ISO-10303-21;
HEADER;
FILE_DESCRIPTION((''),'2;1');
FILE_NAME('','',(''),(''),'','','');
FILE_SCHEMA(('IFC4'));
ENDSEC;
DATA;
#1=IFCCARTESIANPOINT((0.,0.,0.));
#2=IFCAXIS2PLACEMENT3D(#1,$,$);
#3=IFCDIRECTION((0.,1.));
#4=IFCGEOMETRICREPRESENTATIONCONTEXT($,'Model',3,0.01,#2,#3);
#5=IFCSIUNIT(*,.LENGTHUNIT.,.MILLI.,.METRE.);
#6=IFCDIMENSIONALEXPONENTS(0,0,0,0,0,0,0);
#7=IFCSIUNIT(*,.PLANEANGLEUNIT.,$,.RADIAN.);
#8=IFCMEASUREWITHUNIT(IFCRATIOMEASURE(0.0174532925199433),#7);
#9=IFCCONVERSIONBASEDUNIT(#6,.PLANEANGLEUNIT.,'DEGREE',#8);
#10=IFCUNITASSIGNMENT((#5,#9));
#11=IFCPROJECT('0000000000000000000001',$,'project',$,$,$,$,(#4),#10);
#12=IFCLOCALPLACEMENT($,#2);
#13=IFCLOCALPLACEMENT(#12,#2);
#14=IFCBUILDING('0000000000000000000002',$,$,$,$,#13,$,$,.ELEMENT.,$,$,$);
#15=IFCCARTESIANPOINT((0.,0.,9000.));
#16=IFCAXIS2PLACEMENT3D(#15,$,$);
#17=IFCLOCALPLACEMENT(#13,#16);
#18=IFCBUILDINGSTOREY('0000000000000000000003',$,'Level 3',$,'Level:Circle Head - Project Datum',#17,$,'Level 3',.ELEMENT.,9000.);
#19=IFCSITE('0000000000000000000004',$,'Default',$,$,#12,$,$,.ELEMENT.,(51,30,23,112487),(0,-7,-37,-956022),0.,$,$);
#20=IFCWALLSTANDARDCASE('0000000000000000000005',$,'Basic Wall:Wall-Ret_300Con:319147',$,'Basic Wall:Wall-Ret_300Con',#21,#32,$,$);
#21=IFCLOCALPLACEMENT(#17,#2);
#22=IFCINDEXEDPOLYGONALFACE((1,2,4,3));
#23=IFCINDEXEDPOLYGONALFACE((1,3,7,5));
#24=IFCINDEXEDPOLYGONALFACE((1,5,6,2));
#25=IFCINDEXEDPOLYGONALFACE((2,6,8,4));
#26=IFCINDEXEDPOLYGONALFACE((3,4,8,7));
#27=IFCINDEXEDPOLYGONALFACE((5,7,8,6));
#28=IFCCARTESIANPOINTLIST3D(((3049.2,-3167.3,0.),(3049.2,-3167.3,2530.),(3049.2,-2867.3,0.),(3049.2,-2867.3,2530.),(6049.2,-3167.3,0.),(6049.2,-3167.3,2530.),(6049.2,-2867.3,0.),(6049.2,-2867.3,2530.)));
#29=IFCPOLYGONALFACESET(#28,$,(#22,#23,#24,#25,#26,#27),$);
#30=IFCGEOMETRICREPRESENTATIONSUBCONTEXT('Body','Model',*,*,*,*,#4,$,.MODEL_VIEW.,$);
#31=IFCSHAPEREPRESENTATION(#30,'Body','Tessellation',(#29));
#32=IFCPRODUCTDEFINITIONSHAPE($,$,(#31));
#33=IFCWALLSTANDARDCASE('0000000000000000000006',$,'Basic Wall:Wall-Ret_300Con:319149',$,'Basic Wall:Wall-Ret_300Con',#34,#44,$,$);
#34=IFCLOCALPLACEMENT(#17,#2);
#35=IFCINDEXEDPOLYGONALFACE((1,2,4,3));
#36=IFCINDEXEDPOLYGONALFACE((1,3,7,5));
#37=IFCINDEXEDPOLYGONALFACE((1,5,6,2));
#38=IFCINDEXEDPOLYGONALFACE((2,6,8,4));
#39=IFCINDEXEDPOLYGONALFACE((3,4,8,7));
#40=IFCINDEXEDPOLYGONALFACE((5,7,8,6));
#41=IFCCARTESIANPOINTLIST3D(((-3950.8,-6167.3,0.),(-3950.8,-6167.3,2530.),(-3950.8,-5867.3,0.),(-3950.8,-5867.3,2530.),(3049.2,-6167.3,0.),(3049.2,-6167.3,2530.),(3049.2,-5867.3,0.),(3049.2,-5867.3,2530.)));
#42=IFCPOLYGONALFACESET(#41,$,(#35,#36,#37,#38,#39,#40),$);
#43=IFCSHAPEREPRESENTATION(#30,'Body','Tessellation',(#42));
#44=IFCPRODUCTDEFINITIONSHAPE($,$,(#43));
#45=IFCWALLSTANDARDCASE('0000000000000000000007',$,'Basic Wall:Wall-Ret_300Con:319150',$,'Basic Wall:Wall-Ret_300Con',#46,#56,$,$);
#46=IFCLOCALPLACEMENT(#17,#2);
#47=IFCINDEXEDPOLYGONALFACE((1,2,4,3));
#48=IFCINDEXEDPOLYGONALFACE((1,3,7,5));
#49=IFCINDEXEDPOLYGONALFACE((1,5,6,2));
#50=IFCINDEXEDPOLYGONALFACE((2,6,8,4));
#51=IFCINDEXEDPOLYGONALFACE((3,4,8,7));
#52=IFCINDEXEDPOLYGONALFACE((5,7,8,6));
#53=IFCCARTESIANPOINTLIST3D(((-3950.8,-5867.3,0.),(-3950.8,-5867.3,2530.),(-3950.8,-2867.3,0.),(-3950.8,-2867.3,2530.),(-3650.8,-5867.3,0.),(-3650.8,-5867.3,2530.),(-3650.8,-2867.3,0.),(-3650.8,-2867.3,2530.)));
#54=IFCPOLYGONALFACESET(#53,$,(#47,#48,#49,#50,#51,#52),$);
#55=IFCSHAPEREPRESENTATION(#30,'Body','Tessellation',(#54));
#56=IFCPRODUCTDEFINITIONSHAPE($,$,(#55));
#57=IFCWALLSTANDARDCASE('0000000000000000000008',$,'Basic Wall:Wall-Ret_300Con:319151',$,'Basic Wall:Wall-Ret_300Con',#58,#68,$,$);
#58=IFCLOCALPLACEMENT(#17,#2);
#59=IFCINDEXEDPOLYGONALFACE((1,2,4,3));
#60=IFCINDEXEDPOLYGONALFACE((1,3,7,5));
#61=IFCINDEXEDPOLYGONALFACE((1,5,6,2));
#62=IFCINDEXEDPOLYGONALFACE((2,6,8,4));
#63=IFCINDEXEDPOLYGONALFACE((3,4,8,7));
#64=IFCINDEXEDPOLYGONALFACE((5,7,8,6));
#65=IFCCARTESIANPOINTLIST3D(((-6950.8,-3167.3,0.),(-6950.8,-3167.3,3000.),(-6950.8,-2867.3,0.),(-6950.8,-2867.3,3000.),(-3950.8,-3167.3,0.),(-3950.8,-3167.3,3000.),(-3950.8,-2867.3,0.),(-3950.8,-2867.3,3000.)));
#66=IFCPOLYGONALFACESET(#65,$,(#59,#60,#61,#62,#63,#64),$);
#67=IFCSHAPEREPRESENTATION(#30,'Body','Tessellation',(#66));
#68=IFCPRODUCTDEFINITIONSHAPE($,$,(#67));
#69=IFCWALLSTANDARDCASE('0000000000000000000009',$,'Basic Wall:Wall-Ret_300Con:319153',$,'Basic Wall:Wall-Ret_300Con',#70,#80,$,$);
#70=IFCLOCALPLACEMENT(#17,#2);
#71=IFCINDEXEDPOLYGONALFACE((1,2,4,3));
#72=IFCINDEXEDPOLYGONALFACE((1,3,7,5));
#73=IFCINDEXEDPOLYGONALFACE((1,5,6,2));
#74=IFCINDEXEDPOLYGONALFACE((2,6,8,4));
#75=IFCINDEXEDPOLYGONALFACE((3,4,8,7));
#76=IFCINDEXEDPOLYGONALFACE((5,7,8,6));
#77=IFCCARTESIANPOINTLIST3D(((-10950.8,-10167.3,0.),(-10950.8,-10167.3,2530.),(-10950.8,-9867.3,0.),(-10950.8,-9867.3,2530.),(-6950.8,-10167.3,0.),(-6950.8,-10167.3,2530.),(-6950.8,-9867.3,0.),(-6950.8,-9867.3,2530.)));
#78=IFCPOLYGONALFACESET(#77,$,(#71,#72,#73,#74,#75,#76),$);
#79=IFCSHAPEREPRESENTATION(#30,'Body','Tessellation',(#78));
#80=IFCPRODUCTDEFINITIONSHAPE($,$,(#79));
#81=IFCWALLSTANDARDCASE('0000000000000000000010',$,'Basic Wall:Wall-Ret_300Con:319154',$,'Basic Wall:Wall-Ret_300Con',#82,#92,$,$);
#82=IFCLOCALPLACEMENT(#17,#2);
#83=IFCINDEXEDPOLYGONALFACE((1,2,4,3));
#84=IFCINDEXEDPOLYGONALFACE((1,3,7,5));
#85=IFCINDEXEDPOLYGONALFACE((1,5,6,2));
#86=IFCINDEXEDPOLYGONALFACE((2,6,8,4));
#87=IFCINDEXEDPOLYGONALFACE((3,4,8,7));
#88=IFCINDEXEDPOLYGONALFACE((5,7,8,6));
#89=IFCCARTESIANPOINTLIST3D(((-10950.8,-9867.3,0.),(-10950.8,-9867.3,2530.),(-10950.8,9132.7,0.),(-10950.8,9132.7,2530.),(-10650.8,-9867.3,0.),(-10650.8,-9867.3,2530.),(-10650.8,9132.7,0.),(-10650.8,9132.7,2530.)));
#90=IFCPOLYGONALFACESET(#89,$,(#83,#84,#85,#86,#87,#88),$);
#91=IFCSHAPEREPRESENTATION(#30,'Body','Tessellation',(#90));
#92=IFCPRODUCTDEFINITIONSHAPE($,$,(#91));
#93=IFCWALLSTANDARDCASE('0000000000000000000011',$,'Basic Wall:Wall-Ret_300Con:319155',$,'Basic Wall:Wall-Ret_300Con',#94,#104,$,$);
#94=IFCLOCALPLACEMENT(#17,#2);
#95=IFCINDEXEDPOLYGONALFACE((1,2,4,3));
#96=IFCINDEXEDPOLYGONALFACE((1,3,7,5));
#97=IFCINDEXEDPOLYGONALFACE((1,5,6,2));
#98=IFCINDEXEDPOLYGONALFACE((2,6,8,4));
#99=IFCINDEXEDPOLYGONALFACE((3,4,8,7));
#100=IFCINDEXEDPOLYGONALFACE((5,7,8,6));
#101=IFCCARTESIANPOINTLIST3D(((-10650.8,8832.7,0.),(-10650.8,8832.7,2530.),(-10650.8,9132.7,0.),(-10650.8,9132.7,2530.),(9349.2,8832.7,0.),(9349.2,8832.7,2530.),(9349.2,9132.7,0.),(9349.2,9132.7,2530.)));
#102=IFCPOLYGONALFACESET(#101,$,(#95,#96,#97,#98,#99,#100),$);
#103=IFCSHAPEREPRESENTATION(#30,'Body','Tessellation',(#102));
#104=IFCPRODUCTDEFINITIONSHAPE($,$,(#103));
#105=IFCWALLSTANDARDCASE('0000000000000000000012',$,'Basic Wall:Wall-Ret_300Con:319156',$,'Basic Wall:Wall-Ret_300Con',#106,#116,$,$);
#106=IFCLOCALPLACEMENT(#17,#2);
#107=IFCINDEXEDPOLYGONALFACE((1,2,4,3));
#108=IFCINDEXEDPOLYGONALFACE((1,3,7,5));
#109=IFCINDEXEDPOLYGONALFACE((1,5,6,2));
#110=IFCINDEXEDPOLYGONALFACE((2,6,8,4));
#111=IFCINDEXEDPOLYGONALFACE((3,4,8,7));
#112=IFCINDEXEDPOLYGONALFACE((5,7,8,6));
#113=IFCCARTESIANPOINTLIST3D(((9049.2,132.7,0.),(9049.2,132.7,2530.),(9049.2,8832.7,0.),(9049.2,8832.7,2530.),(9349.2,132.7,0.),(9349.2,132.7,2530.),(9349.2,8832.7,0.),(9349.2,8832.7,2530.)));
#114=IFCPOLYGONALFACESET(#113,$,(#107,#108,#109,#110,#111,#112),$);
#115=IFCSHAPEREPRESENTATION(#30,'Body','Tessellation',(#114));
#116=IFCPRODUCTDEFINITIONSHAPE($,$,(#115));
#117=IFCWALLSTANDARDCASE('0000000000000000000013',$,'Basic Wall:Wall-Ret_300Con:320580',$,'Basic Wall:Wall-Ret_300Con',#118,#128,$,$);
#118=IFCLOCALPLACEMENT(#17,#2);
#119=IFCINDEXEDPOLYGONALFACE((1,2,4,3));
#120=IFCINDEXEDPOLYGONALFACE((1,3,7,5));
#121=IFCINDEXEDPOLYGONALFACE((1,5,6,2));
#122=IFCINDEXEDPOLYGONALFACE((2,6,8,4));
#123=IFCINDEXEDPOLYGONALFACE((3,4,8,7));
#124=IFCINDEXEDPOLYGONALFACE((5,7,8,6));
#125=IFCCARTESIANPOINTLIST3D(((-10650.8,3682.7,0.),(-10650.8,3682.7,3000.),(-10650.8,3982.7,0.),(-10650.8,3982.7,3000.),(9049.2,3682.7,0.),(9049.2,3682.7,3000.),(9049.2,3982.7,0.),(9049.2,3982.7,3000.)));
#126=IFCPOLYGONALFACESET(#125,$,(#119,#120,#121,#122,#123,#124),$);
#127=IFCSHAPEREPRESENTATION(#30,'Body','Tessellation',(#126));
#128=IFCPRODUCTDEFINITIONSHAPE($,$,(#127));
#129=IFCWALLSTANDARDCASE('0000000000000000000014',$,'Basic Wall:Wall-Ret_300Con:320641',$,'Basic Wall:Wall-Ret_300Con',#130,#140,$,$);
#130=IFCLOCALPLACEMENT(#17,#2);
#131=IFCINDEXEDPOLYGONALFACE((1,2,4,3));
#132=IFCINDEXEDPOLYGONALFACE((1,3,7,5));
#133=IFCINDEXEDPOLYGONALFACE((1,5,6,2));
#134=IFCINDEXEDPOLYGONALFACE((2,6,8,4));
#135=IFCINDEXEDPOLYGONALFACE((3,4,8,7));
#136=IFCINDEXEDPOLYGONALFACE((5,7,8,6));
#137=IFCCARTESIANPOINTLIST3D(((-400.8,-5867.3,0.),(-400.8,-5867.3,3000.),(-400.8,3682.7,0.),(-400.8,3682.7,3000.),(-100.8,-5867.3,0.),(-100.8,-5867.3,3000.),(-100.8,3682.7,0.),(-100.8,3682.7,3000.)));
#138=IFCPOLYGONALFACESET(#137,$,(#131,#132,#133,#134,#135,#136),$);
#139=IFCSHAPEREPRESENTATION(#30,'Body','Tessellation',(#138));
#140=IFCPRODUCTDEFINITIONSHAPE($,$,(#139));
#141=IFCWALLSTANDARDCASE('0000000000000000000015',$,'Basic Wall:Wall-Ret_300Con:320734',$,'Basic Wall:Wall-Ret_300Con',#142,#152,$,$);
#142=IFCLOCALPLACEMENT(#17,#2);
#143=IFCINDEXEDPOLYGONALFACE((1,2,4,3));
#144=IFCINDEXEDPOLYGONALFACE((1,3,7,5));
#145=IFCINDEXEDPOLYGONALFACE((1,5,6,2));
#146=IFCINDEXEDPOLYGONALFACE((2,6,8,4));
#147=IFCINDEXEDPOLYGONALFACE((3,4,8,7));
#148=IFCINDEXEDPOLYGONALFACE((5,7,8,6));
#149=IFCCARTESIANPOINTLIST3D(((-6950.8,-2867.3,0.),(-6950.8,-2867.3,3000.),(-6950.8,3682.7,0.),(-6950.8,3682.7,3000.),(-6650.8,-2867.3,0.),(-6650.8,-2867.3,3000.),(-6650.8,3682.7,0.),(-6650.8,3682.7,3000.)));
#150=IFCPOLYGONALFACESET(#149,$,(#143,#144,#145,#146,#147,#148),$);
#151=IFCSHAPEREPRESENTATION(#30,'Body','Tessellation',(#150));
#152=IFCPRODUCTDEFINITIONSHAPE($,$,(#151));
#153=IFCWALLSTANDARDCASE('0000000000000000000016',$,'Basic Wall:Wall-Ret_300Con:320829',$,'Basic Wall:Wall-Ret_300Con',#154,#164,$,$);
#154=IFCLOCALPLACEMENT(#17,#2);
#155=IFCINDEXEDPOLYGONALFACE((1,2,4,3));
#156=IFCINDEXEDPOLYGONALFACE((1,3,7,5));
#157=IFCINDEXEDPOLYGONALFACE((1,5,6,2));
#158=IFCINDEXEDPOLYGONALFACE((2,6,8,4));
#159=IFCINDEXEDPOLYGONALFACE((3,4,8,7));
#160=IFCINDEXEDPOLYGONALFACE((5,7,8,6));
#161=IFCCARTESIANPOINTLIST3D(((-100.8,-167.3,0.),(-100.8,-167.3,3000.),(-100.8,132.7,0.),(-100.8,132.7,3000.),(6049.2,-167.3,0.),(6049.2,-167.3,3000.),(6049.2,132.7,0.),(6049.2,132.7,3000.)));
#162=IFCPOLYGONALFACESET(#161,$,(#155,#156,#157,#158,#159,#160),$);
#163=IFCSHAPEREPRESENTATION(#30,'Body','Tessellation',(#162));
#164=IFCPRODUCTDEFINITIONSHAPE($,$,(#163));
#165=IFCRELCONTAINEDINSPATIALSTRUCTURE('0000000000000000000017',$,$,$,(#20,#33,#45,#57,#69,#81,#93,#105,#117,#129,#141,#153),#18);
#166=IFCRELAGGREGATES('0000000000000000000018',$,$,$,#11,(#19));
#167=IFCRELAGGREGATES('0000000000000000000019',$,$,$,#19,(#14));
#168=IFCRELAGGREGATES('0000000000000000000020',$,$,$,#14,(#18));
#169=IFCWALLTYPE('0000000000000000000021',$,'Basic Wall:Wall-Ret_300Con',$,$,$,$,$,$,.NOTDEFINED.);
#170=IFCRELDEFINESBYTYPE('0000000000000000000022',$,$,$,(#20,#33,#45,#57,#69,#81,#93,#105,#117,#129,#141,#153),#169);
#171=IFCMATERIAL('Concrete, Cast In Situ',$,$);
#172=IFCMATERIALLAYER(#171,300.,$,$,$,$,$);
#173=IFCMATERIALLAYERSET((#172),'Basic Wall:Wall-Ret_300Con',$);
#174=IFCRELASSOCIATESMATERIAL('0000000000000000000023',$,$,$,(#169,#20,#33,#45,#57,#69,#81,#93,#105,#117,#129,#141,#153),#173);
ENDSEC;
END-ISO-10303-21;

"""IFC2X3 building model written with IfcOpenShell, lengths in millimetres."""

from ifc_helpers import new_model, entity, si_unit, converted_unit, direction, frame, frame_2d, origin, place, context, subcontext, project, spatial, polyline, rectangle, extrude, clip, bounded_halfspace, material, layer, layer_set, layer_usage, type_object, element, save


model = new_model("IFC2X3")

# Units and contexts
model_context = context("Model", 3, precision=0.01, world=origin(), true_north=direction((0.0, 1.0)))
body_context = subcontext(model_context, "Body", "Model", "MODEL_VIEW")
ifc_project = project(units=[si_unit("LENGTHUNIT", "METRE", prefix="MILLI"), converted_unit("PLANEANGLEUNIT", "DEGREE", entity("IfcRatioMeasure", 0.0174532925199433), si_unit("PLANEANGLEUNIT", "RADIAN"), dimensions=[0, 0, 0, 0, 0, 0, 0])], contexts=[model_context])

# Site, building, storey
site_placement = place(None, origin())
site = spatial("IfcSite", under=ifc_project, at=site_placement, Name="Default", CompositionType="ELEMENT", RefLatitude=(51, 30, 23, 112487), RefLongitude=(0, -7, -37, -956022), RefElevation=0.0)
building_placement = place(site_placement, origin())
building = spatial("IfcBuilding", under=site, at=building_placement, CompositionType="ELEMENT")
storey_placement = place(building_placement, frame((0.0, 0.0, 9000.0)))
storey = spatial("IfcBuildingStorey", under=building, at=storey_placement, Name="Level 3", ObjectType="Level:Circle Head - Project Datum", LongName="Level 3", CompositionType="ELEMENT", Elevation=9000.0)

# Walls
ifc_material_1 = material(Name="Concrete, Cast In Situ")
ifc_layer_1 = layer(ifc_material_1, 300.0)
ifc_layer_set_1 = layer_set([ifc_layer_1], Name="Basic Wall:Wall-Ret_300Con")
wall_type = type_object("IfcWallType", Name="Basic Wall:Wall-Ret_300Con", PredefinedType="NOTDEFINED", material=ifc_layer_set_1)
ifc_layer_usage_1 = layer_usage(ifc_layer_set_1, "AXIS2", "NEGATIVE", 150.0)
wall_1_placement = place(storey_placement, frame((6049.2, -3017.3, 0.0), z_axis=(0.0, 0.0, 1.0), x_axis=(-1.0, 0.0, 0.0)))
element("IfcWallStandardCase", 1, at=wall_1_placement, inside=storey, type_object=wall_type, material=ifc_layer_usage_1, Name="Basic Wall:Wall-Ret_300Con:319147", ObjectType="Basic Wall:Wall-Ret_300Con", context=body_context, shape_type="Clipping", body=[
    clip(extrude(rectangle(XDim=3000.0, YDim=300.0, at=frame_2d((1500.0, 0.0), x_axis=(-1.0, 0.0))), origin(), (0.0, 0.0, 1.0), 2530.0), bounded_halfspace(frame((0.0, -150.0, 2530.0), z_axis=(0.0, 0.0, -1.0), x_axis=(-1.0, 0.0, 0.0)), True, frame((0.0, -150.0, 2530.0)), polyline([(0.0, 0.0), (3000.0, 0.0), (3000.0, 298.0), (2701.3, 298.0), (0.0, 298.0), (0.0, 0.0)]))),
])
ifc_layer_usage_2 = layer_usage(ifc_layer_set_1, "AXIS2", "NEGATIVE", 150.0)
wall_2_placement = place(storey_placement, frame((3049.2, -6017.3, 0.0), z_axis=(0.0, 0.0, 1.0), x_axis=(-1.0, 0.0, 0.0)))
element("IfcWallStandardCase", 2, at=wall_2_placement, inside=storey, type_object=wall_type, material=ifc_layer_usage_2, Name="Basic Wall:Wall-Ret_300Con:319149", ObjectType="Basic Wall:Wall-Ret_300Con", context=body_context, shape_type="Clipping", body=[
    clip(extrude(rectangle(XDim=7000.0, YDim=300.0, at=frame_2d((3500.0, 0.0), x_axis=(-1.0, 0.0))), origin(), (0.0, 0.0, 1.0), 2530.0), bounded_halfspace(frame((0.0, -150.0, 2530.0), z_axis=(0.0, 0.0, -1.0), x_axis=(-1.0, 0.0, 0.0)), True, frame((0.0, -150.0, 2530.0)), polyline([(0.0, 0.0), (6700.0, 0.0), (7000.0, 0.0), (7000.0, 298.0), (0.0, 298.0), (0.0, 0.0)]))),
])
ifc_layer_usage_3 = layer_usage(ifc_layer_set_1, "AXIS2", "NEGATIVE", 150.0)
wall_3_placement = place(storey_placement, frame((-3800.8, -5867.3, 0.0), z_axis=(0.0, 0.0, 1.0), x_axis=(0.0, 1.0, 0.0)))
element("IfcWallStandardCase", 3, at=wall_3_placement, inside=storey, type_object=wall_type, material=ifc_layer_usage_3, Name="Basic Wall:Wall-Ret_300Con:319150", ObjectType="Basic Wall:Wall-Ret_300Con", context=body_context, shape_type="Clipping", body=[
    clip(extrude(rectangle(XDim=3000.0, YDim=300.0, at=frame_2d((1500.0, 0.0), x_axis=(-1.0, 0.0))), origin(), (0.0, 0.0, 1.0), 2530.0), bounded_halfspace(frame((0.0, -150.0, 2530.0), z_axis=(0.0, 0.0, -1.0), x_axis=(0.0, -1.0, 0.0)), True, frame((0.0, -150.0, 2530.0)), polyline([(0.0, 0.0), (3000.0, 0.0), (3000.0, 300.0), (0.0, 300.0), (0.0, 0.0)]))),
])
ifc_layer_usage_4 = layer_usage(ifc_layer_set_1, "AXIS2", "NEGATIVE", 150.0)
wall_4_placement = place(storey_placement, frame((-3950.8, -3017.3, 0.0), z_axis=(0.0, 0.0, 1.0), x_axis=(-1.0, 0.0, 0.0)))
element("IfcWallStandardCase", 4, at=wall_4_placement, inside=storey, type_object=wall_type, material=ifc_layer_usage_4, Name="Basic Wall:Wall-Ret_300Con:319151", ObjectType="Basic Wall:Wall-Ret_300Con", context=body_context, shape_type="SweptSolid", body=[
    extrude(rectangle(XDim=3000.0, YDim=300.0, at=frame_2d((1500.0, 0.0), x_axis=(-1.0, 0.0))), origin(), (0.0, 0.0, 1.0), 3000.0),
])
ifc_layer_usage_5 = layer_usage(ifc_layer_set_1, "AXIS2", "NEGATIVE", 150.0)
wall_5_placement = place(storey_placement, frame((-6950.8, -10017.3, 0.0), z_axis=(0.0, 0.0, 1.0), x_axis=(-1.0, 0.0, 0.0)))
element("IfcWallStandardCase", 5, at=wall_5_placement, inside=storey, type_object=wall_type, material=ifc_layer_usage_5, Name="Basic Wall:Wall-Ret_300Con:319153", ObjectType="Basic Wall:Wall-Ret_300Con", context=body_context, shape_type="Clipping", body=[
    clip(extrude(rectangle(XDim=4000.0, YDim=300.0, at=frame_2d((2000.0, 0.0), x_axis=(-1.0, 0.0))), origin(), (0.0, 0.0, 1.0), 2530.0), bounded_halfspace(frame((0.0, -150.0, 2530.0), z_axis=(0.0, 0.0, -1.0), x_axis=(-1.0, 0.0, 0.0)), True, frame((0.0, -150.0, 2530.0)), polyline([(0.0, 0.0), (3700.0, 0.0), (4000.0, 0.0), (4000.0, 298.0), (0.0, 298.0), (0.0, 0.0)]))),
])
ifc_layer_usage_6 = layer_usage(ifc_layer_set_1, "AXIS2", "NEGATIVE", 150.0)
wall_6_placement = place(storey_placement, frame((-10800.8, -9867.3, 0.0), z_axis=(0.0, 0.0, 1.0), x_axis=(0.0, 1.0, 0.0)))
element("IfcWallStandardCase", 6, at=wall_6_placement, inside=storey, type_object=wall_type, material=ifc_layer_usage_6, Name="Basic Wall:Wall-Ret_300Con:319154", ObjectType="Basic Wall:Wall-Ret_300Con", context=body_context, shape_type="Clipping", body=[
    clip(extrude(rectangle(XDim=19000.0, YDim=300.0, at=frame_2d((9500.0, 0.0), x_axis=(-1.0, 0.0))), origin(), (0.0, 0.0, 1.0), 2530.0), bounded_halfspace(frame((0.0, -150.0, 2530.0), z_axis=(0.0, 0.0, -1.0), x_axis=(0.0, -1.0, 0.0)), True, frame((0.0, -150.0, 2530.0)), polyline([(0.0, 0.0), (18700.0, 0.0), (19000.0, 0.0), (19000.0, 300.0), (0.0, 300.0), (0.0, 0.0)]))),
])
ifc_layer_usage_7 = layer_usage(ifc_layer_set_1, "AXIS2", "NEGATIVE", 150.0)
wall_7_placement = place(storey_placement, frame((-10650.8, 8982.7, 0.0)))
element("IfcWallStandardCase", 7, at=wall_7_placement, inside=storey, type_object=wall_type, material=ifc_layer_usage_7, Name="Basic Wall:Wall-Ret_300Con:319155", ObjectType="Basic Wall:Wall-Ret_300Con", context=body_context, shape_type="Clipping", body=[
    clip(extrude(rectangle(XDim=20000.0, YDim=300.0, at=frame_2d((10000.0, 0.0), x_axis=(-1.0, 0.0))), origin(), (0.0, 0.0, 1.0), 2530.0), bounded_halfspace(frame((0.0, -150.0, 2530.0), z_axis=(0.0, 0.0, -1.0), x_axis=(1.0, 0.0, 0.0)), True, frame((0.0, -150.0, 2530.0)), polyline([(0.0, 0.0), (19700.0, 0.0), (19998.7, 0.0), (19998.7, 300.0), (0.0, 300.0), (0.0, 0.0)]))),
])
ifc_layer_usage_8 = layer_usage(ifc_layer_set_1, "AXIS2", "NEGATIVE", 150.0)
wall_8_placement = place(storey_placement, frame((9199.2, 8832.7, 0.0), z_axis=(0.0, 0.0, 1.0), x_axis=(0.0, -1.0, 0.0)))
element("IfcWallStandardCase", 8, at=wall_8_placement, inside=storey, type_object=wall_type, material=ifc_layer_usage_8, Name="Basic Wall:Wall-Ret_300Con:319156", ObjectType="Basic Wall:Wall-Ret_300Con", context=body_context, shape_type="Clipping", body=[
    clip(extrude(rectangle(XDim=8700.0, YDim=300.0, at=frame_2d((4350.0, 0.0), x_axis=(-1.0, 0.0))), origin(), (0.0, 0.0, 1.0), 2530.0), bounded_halfspace(frame((0.0, -150.0, 2530.0), z_axis=(0.0, 0.0, -1.0), x_axis=(0.0, 1.0, 0.0)), True, frame((0.0, -150.0, 2530.0)), polyline([(0.0, 0.0), (8700.0, 0.0), (8700.0, 298.7), (0.0, 298.7), (0.0, 0.0)]))),
])
ifc_layer_usage_9 = layer_usage(ifc_layer_set_1, "AXIS2", "NEGATIVE", 150.0)
wall_9_placement = place(storey_placement, frame((-10650.8, 3832.7, 0.0)))
element("IfcWallStandardCase", 9, at=wall_9_placement, inside=storey, type_object=wall_type, material=ifc_layer_usage_9, Name="Basic Wall:Wall-Ret_300Con:320580", ObjectType="Basic Wall:Wall-Ret_300Con", context=body_context, shape_type="SweptSolid", body=[
    extrude(rectangle(XDim=19700.0, YDim=300.0, at=frame_2d((9850.0, 0.0), x_axis=(-1.0, 0.0))), origin(), (0.0, 0.0, 1.0), 3000.0),
])
ifc_layer_usage_10 = layer_usage(ifc_layer_set_1, "AXIS2", "NEGATIVE", 150.0)
wall_10_placement = place(storey_placement, frame((-250.8, 3682.7, 0.0), z_axis=(0.0, 0.0, 1.0), x_axis=(0.0, -1.0, 0.0)))
element("IfcWallStandardCase", 10, at=wall_10_placement, inside=storey, type_object=wall_type, material=ifc_layer_usage_10, Name="Basic Wall:Wall-Ret_300Con:320641", ObjectType="Basic Wall:Wall-Ret_300Con", context=body_context, shape_type="SweptSolid", body=[
    extrude(rectangle(XDim=9550.0, YDim=300.0, at=frame_2d((4775.0, 0.0), x_axis=(-1.0, 0.0))), origin(), (0.0, 0.0, 1.0), 3000.0),
])
ifc_layer_usage_11 = layer_usage(ifc_layer_set_1, "AXIS2", "NEGATIVE", 150.0)
wall_11_placement = place(storey_placement, frame((-6800.8, -2867.3, 0.0), z_axis=(0.0, 0.0, 1.0), x_axis=(0.0, 1.0, 0.0)))
element("IfcWallStandardCase", 11, at=wall_11_placement, inside=storey, type_object=wall_type, material=ifc_layer_usage_11, Name="Basic Wall:Wall-Ret_300Con:320734", ObjectType="Basic Wall:Wall-Ret_300Con", context=body_context, shape_type="SweptSolid", body=[
    extrude(rectangle(XDim=6550.0, YDim=300.0, at=frame_2d((3275.0, 0.0), x_axis=(-1.0, 0.0))), origin(), (0.0, 0.0, 1.0), 3000.0),
])
ifc_layer_usage_12 = layer_usage(ifc_layer_set_1, "AXIS2", "NEGATIVE", 150.0)
wall_12_placement = place(storey_placement, frame((6049.2, -17.3, 0.0), z_axis=(0.0, 0.0, 1.0), x_axis=(-1.0, 0.0, 0.0)))
element("IfcWallStandardCase", 12, at=wall_12_placement, inside=storey, type_object=wall_type, material=ifc_layer_usage_12, Name="Basic Wall:Wall-Ret_300Con:320829", ObjectType="Basic Wall:Wall-Ret_300Con", context=body_context, shape_type="SweptSolid", body=[
    extrude(rectangle(XDim=6150.0, YDim=300.0, at=frame_2d((3075.0, 0.0), x_axis=(-1.0, 0.0))), origin(), (0.0, 0.0, 1.0), 3000.0),
])

save(model, "model.ifc")
